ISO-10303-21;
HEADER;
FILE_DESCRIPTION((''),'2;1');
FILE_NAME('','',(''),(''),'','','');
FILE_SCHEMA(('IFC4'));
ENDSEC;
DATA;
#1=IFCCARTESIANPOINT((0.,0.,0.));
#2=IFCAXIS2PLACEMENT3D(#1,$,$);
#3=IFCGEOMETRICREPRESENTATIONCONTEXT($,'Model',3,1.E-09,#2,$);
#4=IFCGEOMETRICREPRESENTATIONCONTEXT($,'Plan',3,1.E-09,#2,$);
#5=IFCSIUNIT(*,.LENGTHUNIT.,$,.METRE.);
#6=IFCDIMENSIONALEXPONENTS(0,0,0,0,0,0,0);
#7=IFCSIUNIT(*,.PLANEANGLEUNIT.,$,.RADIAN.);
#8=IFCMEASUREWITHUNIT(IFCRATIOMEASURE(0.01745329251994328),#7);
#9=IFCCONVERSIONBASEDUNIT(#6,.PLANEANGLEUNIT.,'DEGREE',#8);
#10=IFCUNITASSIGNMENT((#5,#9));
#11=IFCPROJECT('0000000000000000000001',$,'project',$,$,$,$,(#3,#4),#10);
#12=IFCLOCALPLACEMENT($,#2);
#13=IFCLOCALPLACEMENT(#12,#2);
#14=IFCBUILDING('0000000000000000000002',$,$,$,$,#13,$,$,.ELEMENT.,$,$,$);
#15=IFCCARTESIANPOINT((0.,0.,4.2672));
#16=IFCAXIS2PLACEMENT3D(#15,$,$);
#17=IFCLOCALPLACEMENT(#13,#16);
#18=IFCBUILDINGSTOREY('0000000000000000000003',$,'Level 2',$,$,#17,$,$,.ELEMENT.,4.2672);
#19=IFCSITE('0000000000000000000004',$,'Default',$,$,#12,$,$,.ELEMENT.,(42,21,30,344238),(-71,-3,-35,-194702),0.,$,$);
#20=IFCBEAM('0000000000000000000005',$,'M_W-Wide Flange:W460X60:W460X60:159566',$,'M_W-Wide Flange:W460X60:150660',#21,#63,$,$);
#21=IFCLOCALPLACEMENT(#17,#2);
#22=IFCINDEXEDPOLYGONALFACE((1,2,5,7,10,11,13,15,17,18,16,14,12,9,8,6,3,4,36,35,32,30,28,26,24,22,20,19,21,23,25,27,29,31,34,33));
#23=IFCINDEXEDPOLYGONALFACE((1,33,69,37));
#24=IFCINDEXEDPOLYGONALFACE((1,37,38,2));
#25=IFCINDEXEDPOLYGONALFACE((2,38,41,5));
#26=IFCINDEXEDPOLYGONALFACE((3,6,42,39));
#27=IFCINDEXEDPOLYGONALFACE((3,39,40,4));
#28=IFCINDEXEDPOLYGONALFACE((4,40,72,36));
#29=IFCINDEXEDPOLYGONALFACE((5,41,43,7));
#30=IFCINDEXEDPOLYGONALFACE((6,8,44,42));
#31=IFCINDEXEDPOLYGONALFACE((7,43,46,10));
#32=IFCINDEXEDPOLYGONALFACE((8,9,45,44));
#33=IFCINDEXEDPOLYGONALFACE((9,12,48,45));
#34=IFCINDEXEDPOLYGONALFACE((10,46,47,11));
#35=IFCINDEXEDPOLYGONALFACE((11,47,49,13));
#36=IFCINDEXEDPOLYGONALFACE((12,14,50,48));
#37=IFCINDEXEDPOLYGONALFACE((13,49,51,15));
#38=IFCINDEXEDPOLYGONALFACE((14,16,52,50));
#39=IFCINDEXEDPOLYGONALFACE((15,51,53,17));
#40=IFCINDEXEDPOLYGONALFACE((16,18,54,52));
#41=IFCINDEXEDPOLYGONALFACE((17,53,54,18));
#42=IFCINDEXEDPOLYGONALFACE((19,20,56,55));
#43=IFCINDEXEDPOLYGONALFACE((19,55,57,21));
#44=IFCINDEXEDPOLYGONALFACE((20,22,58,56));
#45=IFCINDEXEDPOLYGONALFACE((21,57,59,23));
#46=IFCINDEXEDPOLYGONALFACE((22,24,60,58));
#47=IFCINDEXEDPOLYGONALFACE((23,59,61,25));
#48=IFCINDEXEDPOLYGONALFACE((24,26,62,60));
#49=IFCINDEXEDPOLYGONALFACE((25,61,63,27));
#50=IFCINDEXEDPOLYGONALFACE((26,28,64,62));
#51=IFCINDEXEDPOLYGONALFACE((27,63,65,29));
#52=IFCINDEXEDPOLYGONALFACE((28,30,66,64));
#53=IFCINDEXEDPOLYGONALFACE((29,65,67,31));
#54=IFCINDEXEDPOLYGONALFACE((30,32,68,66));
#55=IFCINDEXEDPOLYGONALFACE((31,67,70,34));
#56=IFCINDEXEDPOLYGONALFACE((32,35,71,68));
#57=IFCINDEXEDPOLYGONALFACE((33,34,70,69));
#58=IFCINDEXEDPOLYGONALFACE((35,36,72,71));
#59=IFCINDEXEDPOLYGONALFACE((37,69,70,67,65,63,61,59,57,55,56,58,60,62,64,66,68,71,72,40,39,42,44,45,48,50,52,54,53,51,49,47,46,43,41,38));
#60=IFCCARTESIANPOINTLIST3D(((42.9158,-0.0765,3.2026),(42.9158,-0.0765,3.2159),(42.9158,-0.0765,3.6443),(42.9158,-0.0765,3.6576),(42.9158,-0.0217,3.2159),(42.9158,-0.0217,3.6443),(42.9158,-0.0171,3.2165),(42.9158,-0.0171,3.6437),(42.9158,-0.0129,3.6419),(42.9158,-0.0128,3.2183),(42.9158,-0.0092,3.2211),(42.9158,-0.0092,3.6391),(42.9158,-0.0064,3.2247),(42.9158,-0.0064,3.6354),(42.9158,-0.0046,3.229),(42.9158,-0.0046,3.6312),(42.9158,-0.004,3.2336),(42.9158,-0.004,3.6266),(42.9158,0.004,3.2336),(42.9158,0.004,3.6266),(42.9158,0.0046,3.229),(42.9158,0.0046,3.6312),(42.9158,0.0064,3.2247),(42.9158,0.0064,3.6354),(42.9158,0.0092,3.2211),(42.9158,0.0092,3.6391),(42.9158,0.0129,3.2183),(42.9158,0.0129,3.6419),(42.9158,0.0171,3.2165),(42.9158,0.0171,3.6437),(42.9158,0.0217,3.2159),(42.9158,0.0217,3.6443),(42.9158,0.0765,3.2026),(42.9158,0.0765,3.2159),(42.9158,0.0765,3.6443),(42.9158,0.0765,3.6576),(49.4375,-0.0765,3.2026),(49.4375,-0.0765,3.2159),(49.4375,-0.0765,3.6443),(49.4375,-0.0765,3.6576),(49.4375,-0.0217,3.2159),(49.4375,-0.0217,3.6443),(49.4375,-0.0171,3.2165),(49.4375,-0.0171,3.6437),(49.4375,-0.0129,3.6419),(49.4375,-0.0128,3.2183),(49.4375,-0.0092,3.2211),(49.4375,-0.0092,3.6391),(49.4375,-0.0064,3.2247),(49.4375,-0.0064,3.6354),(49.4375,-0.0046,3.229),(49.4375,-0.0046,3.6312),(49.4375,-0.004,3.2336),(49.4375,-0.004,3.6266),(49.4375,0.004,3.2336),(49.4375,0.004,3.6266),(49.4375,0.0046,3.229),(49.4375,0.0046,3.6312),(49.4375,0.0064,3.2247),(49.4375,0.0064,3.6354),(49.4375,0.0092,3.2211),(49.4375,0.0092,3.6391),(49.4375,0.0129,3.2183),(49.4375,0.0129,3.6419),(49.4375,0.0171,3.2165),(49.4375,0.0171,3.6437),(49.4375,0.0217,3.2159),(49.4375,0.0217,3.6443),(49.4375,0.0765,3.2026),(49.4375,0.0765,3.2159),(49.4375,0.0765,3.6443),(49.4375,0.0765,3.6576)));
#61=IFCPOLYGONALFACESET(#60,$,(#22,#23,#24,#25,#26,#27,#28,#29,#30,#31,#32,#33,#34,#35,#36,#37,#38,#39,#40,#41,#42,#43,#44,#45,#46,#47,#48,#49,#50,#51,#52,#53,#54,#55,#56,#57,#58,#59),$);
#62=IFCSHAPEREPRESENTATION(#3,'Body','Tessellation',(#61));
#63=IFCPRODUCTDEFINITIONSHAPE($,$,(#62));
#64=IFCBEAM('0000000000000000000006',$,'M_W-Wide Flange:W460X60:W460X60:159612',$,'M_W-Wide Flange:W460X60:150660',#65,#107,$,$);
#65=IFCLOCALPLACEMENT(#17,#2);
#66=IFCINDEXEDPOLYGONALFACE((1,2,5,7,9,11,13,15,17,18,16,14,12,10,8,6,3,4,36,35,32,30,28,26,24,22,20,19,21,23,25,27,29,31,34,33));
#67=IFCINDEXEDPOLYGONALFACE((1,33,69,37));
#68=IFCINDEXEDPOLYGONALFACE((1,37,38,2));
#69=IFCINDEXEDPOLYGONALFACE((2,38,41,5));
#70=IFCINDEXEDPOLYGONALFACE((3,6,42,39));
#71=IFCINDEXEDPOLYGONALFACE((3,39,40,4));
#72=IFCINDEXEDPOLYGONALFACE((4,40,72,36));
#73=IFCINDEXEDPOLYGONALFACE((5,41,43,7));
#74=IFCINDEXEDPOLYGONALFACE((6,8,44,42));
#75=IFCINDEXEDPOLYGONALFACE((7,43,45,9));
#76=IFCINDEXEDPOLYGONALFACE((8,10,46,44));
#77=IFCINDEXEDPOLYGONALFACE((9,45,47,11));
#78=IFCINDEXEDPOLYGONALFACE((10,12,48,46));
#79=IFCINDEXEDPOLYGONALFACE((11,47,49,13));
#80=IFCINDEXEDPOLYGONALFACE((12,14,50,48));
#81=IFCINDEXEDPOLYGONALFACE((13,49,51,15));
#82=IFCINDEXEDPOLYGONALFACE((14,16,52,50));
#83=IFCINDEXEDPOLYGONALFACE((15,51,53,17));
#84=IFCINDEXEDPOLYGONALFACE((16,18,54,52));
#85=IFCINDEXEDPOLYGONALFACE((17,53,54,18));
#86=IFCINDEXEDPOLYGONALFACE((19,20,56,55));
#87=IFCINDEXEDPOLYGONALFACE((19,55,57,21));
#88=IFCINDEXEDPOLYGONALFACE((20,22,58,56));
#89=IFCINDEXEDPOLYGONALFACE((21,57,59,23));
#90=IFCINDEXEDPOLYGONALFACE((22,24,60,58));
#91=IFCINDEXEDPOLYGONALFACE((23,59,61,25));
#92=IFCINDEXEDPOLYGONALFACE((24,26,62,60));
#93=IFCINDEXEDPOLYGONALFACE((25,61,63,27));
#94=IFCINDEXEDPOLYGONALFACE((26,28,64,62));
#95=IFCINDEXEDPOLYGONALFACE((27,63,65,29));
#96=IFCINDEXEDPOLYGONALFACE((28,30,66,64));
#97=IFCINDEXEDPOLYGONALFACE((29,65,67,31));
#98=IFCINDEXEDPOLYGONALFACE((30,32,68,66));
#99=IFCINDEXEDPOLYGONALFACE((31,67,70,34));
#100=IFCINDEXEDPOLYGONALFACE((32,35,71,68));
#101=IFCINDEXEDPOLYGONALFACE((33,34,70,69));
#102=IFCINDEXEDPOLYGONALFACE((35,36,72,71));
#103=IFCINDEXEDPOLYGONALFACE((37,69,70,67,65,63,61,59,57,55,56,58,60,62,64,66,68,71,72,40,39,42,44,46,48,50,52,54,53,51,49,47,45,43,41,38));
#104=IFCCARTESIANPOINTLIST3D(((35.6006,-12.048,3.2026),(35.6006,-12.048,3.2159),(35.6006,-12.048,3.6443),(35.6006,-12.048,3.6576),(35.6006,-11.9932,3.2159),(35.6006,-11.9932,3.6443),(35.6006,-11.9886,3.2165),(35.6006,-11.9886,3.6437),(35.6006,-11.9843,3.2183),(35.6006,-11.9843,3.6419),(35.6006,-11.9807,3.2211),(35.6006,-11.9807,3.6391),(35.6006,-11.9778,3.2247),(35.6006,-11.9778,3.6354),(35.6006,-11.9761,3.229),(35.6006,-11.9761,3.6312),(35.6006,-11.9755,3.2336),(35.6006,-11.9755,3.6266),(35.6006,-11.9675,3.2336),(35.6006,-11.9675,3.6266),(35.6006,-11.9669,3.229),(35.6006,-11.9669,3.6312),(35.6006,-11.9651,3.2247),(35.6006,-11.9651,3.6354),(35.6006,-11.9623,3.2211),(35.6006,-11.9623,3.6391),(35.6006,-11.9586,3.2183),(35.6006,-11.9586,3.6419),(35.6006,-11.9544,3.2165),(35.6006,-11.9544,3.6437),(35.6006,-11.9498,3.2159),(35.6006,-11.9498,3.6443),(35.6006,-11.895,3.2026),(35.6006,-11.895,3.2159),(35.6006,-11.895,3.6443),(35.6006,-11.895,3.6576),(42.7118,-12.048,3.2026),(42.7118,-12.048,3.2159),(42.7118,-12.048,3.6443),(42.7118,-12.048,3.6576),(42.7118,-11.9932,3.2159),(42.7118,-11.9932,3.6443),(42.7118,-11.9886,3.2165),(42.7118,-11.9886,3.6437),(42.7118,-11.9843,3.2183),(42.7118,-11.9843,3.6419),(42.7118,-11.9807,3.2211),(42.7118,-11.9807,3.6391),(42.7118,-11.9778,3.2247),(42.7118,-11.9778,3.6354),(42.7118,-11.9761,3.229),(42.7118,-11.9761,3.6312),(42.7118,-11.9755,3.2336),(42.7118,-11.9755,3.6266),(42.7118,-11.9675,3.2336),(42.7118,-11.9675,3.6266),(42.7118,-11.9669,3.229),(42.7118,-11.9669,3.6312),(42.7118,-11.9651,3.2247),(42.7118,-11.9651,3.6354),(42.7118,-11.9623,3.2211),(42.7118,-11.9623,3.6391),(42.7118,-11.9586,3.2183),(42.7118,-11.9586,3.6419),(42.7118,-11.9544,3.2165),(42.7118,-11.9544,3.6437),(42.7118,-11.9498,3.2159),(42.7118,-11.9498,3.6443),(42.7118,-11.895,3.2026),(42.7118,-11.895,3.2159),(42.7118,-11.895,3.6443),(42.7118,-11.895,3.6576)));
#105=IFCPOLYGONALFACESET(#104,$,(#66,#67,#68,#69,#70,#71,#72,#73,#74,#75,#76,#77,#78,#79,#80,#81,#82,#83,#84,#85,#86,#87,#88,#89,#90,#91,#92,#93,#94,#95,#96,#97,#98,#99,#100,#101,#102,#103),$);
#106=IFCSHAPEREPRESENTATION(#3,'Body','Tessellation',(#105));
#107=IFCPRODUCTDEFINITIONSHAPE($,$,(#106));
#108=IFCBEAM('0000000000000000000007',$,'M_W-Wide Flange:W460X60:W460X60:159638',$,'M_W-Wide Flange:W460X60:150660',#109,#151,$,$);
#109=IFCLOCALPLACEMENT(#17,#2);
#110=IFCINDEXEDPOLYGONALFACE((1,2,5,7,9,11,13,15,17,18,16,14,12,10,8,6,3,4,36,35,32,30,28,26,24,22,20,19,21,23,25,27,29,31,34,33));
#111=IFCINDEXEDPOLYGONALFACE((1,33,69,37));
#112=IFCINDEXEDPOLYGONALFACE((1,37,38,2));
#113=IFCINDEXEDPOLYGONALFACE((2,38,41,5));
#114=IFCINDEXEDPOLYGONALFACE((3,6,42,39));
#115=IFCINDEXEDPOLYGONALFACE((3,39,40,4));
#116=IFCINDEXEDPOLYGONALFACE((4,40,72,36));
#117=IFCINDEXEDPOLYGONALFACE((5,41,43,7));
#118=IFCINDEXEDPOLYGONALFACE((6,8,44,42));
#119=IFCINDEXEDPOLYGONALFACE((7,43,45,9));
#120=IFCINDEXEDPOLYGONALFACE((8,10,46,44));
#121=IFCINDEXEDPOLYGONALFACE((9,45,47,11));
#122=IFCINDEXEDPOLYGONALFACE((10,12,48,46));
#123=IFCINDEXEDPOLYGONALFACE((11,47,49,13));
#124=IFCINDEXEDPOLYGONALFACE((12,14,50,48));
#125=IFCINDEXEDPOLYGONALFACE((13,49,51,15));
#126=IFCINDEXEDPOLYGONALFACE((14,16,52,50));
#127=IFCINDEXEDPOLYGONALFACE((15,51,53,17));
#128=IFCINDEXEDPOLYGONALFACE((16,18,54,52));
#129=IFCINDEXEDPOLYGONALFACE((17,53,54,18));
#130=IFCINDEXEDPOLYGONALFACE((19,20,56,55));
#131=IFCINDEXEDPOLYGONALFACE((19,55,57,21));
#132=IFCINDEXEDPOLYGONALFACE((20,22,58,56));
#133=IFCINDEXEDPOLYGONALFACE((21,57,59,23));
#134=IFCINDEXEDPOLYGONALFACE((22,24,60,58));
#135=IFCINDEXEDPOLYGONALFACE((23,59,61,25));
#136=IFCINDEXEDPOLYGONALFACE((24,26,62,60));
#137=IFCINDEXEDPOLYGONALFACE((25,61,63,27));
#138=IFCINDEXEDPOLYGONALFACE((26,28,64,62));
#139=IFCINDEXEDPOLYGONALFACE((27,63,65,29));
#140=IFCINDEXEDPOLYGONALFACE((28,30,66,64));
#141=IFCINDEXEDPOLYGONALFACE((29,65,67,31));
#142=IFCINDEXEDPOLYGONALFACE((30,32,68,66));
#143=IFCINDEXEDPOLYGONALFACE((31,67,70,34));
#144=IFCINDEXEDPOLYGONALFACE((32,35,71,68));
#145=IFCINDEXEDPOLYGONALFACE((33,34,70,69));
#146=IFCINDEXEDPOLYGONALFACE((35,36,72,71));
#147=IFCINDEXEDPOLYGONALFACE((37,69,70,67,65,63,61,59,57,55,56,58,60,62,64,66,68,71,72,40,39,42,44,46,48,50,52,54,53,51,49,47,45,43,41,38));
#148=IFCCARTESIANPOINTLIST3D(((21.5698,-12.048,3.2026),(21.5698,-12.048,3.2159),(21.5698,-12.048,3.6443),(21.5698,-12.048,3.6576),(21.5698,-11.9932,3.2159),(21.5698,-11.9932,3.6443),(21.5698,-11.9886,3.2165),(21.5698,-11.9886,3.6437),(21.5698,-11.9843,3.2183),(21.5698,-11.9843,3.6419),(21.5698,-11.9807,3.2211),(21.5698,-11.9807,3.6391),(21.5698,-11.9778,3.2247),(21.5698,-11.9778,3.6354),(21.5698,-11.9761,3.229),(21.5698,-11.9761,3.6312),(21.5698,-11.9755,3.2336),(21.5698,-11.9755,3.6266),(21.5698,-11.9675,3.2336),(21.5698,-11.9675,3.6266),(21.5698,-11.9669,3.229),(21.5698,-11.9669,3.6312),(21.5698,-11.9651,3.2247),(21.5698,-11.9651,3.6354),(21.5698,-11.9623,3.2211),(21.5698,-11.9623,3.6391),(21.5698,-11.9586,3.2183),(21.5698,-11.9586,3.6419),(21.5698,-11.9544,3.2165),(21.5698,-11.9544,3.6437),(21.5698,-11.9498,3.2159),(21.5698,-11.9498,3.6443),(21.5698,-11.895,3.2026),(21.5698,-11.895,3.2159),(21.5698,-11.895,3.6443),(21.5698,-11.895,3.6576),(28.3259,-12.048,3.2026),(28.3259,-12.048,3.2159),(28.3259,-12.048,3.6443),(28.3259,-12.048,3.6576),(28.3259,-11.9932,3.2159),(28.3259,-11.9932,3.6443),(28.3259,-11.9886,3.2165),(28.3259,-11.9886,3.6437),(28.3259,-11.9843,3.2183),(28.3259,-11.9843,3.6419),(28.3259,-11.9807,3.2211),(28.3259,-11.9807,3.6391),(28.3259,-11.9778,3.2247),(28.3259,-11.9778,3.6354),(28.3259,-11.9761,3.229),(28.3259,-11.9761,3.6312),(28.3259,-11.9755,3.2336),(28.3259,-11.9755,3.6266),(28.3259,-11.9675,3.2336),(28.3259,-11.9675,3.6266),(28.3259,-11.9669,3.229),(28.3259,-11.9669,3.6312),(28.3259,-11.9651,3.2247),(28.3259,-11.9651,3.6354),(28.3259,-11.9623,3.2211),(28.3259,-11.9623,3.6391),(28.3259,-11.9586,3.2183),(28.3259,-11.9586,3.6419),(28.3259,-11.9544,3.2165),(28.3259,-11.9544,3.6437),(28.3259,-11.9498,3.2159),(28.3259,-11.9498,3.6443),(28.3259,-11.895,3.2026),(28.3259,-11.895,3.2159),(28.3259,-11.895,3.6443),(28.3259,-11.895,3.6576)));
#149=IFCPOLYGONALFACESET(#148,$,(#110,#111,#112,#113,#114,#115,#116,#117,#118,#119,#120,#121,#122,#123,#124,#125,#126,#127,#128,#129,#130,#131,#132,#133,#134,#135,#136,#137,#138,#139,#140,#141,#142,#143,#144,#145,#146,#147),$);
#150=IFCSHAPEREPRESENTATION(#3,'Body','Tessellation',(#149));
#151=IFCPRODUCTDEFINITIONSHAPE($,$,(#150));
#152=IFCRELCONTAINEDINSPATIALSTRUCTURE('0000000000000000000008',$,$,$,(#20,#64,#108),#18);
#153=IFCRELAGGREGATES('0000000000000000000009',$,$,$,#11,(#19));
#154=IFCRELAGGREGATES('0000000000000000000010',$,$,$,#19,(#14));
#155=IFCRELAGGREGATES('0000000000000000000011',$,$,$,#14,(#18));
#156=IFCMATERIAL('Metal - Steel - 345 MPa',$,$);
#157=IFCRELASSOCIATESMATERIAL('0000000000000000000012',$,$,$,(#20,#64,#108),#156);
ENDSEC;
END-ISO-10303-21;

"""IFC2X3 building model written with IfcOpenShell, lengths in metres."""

from ifc_helpers import new_model, entity, si_unit, converted_unit, frame, frame_2d, origin, place, context, project, spatial, polyline, circle_curve, parameter, trimmed, segment, composite_curve, outline, extrude, material, element, save


model = new_model("IFC2X3")

# Units and contexts
model_context = context("Model", 3, precision=1e-09, world=origin())
plan_context = context("Plan", 3, precision=1e-09, world=origin())
ifc_project = project(units=[si_unit("LENGTHUNIT", "METRE"), converted_unit("PLANEANGLEUNIT", "DEGREE", entity("IfcRatioMeasure", 0.01745329251994328), si_unit("PLANEANGLEUNIT", "RADIAN"), dimensions=[0, 0, 0, 0, 0, 0, 0])], contexts=[model_context, plan_context])

# Site, building, storey
site_placement = place(None, origin())
site = spatial("IfcSite", under=ifc_project, at=site_placement, Name="Default", CompositionType="ELEMENT", RefLatitude=(42, 21, 30, 344238), RefLongitude=(-71, -3, -35, -194702), RefElevation=0.0)
building_placement = place(site_placement, origin())
building = spatial("IfcBuilding", under=site, at=building_placement, CompositionType="ELEMENT")
storey_placement = place(building_placement, frame((0.0, 0.0, 4.2672)))
storey = spatial("IfcBuildingStorey", under=building, at=storey_placement, Name="Level 2", CompositionType="ELEMENT", Elevation=4.2672)

# Shared definitions
ifc_material = material(Name="Metal - Steel - 345 MPa")

# Beams
beam_1_placement = place(storey_placement, frame((42.8138, 0.0, 3.6576), z_axis=(0.0, 0.0, 1.0), x_axis=(0.0, -1.0, 0.0)))
element("IfcBeam", 1, at=beam_1_placement, inside=storey, material=ifc_material, Name="M_W-Wide Flange:W460X60:W460X60:159566", ObjectType="M_W-Wide Flange:W460X60:150660", context=model_context, shape_type="SweptSolid", body=[
    extrude(outline(composite_curve([segment(polyline([(-0.0765, -0.2142), (-0.0765, -0.2275)]), True, "CONTINUOUS"), segment(polyline([(-0.0765, -0.2275), (0.0765, -0.2275)]), True, "CONTINUOUS"), segment(polyline([(0.0765, -0.2275), (0.0765, -0.2142)]), True, "CONTINUOUS"), segment(polyline([(0.0765, -0.2142), (0.0217, -0.2142)]), True, "CONTINUOUS"), segment(trimmed(circle_curve(frame_2d((0.0217, -0.1965), x_axis=(0.0, -1.0)), 0.0177), [parameter(270.0)], [parameter(360.0)], True, "PARAMETER"), False, "CONTINUOUS"), segment(polyline([(0.004, -0.1965), (0.004, 0.1965)]), True, "CONTINUOUS"), segment(trimmed(circle_curve(frame_2d((0.0217, 0.1965), x_axis=(-1.0, 0.0)), 0.0177), [parameter(270.0)], [parameter(360.0)], True, "PARAMETER"), False, "CONTINUOUS"), segment(polyline([(0.0217, 0.2142), (0.0765, 0.2142)]), True, "CONTINUOUS"), segment(polyline([(0.0765, 0.2142), (0.0765, 0.2275)]), True, "CONTINUOUS"), segment(polyline([(0.0765, 0.2275), (-0.0765, 0.2275)]), True, "CONTINUOUS"), segment(polyline([(-0.0765, 0.2275), (-0.0765, 0.2142)]), True, "CONTINUOUS"), segment(polyline([(-0.0765, 0.2142), (-0.0217, 0.2142)]), True, "CONTINUOUS"), segment(trimmed(circle_curve(frame_2d((-0.0217, 0.1965), x_axis=(0.0, 1.0)), 0.0177), [parameter(270.0)], [parameter(360.0)], True, "PARAMETER"), False, "CONTINUOUS"), segment(polyline([(-0.004, 0.1965), (-0.004, -0.1965)]), True, "CONTINUOUS"), segment(trimmed(circle_curve(frame_2d((-0.0217, -0.1965), x_axis=(1.0, 0.0)), 0.0177), [parameter(270.0)], [parameter(0.0)], True, "PARAMETER"), False, "CONTINUOUS"), segment(polyline([(-0.0217, -0.2142), (-0.0765, -0.2142)]), True, "CONTINUOUS")], self_intersect=False)), frame((0.0, 0.102, -0.2275), z_axis=(0.0, -1.0, 0.0), x_axis=(1.0, 0.0, 0.0)), (0.0, 0.0, -1.0), 6.5217),
])
beam_2_placement = place(storey_placement, frame((42.8138, -11.9715, 3.6576), z_axis=(0.0, 0.0, 1.0), x_axis=(0.0, 1.0, 0.0)))
element("IfcBeam", 2, at=beam_2_placement, inside=storey, material=ifc_material, Name="M_W-Wide Flange:W460X60:W460X60:159612", ObjectType="M_W-Wide Flange:W460X60:150660", context=model_context, shape_type="SweptSolid", body=[
    extrude(outline(composite_curve([segment(polyline([(0.2142, -0.0765), (0.2275, -0.0765)]), True, "CONTINUOUS"), segment(polyline([(0.2275, -0.0765), (0.2275, 0.0765)]), True, "CONTINUOUS"), segment(polyline([(0.2275, 0.0765), (0.2142, 0.0765)]), True, "CONTINUOUS"), segment(polyline([(0.2142, 0.0765), (0.2142, 0.0217)]), True, "CONTINUOUS"), segment(trimmed(circle_curve(frame_2d((0.1965, 0.0217), x_axis=(1.0, 0.0)), 0.0177), [parameter(270.0)], [parameter(360.0)], True, "PARAMETER"), False, "CONTINUOUS"), segment(polyline([(0.1965, 0.004), (-0.1965, 0.004)]), True, "CONTINUOUS"), segment(trimmed(circle_curve(frame_2d((-0.1965, 0.0217), x_axis=(0.0, -1.0)), 0.0177), [parameter(270.0)], [parameter(360.0)], True, "PARAMETER"), False, "CONTINUOUS"), segment(polyline([(-0.2142, 0.0217), (-0.2142, 0.0765)]), True, "CONTINUOUS"), segment(polyline([(-0.2142, 0.0765), (-0.2275, 0.0765)]), True, "CONTINUOUS"), segment(polyline([(-0.2275, 0.0765), (-0.2275, -0.0765)]), True, "CONTINUOUS"), segment(polyline([(-0.2275, -0.0765), (-0.2142, -0.0765)]), True, "CONTINUOUS"), segment(polyline([(-0.2142, -0.0765), (-0.2142, -0.0217)]), True, "CONTINUOUS"), segment(trimmed(circle_curve(frame_2d((-0.1965, -0.0217), x_axis=(-1.0, 0.0)), 0.0177), [parameter(270.0)], [parameter(360.0)], True, "PARAMETER"), False, "CONTINUOUS"), segment(polyline([(-0.1965, -0.004), (0.1965, -0.004)]), True, "CONTINUOUS"), segment(trimmed(circle_curve(frame_2d((0.1965, -0.0217), x_axis=(0.0, 1.0)), 0.0177), [parameter(270.0)], [parameter(0.0)], True, "PARAMETER"), False, "CONTINUOUS"), segment(polyline([(0.2142, -0.0217), (0.2142, -0.0765)]), True, "CONTINUOUS")], self_intersect=False)), frame((0.0, 7.2132, -0.2275), z_axis=(0.0, -1.0, 0.0), x_axis=(0.0, 0.0, -1.0)), (0.0, 0.0, 1.0), 7.1112),
])
beam_3_placement = place(storey_placement, frame((28.4279, -11.9715, 3.6576), z_axis=(0.0, 0.0, 1.0), x_axis=(0.0, 1.0, 0.0)))
element("IfcBeam", 3, at=beam_3_placement, inside=storey, material=ifc_material, Name="M_W-Wide Flange:W460X60:W460X60:159638", ObjectType="M_W-Wide Flange:W460X60:150660", context=model_context, shape_type="SweptSolid", body=[
    extrude(outline(composite_curve([segment(polyline([(0.2142, -0.0765), (0.2275, -0.0765)]), True, "CONTINUOUS"), segment(polyline([(0.2275, -0.0765), (0.2275, 0.0765)]), True, "CONTINUOUS"), segment(polyline([(0.2275, 0.0765), (0.2142, 0.0765)]), True, "CONTINUOUS"), segment(polyline([(0.2142, 0.0765), (0.2142, 0.0217)]), True, "CONTINUOUS"), segment(trimmed(circle_curve(frame_2d((0.1965, 0.0217), x_axis=(1.0, 0.0)), 0.0177), [parameter(270.0)], [parameter(360.0)], True, "PARAMETER"), False, "CONTINUOUS"), segment(polyline([(0.1965, 0.004), (-0.1965, 0.004)]), True, "CONTINUOUS"), segment(trimmed(circle_curve(frame_2d((-0.1965, 0.0217), x_axis=(0.0, -1.0)), 0.0177), [parameter(270.0)], [parameter(360.0)], True, "PARAMETER"), False, "CONTINUOUS"), segment(polyline([(-0.2142, 0.0217), (-0.2142, 0.0765)]), True, "CONTINUOUS"), segment(polyline([(-0.2142, 0.0765), (-0.2275, 0.0765)]), True, "CONTINUOUS"), segment(polyline([(-0.2275, 0.0765), (-0.2275, -0.0765)]), True, "CONTINUOUS"), segment(polyline([(-0.2275, -0.0765), (-0.2142, -0.0765)]), True, "CONTINUOUS"), segment(polyline([(-0.2142, -0.0765), (-0.2142, -0.0217)]), True, "CONTINUOUS"), segment(trimmed(circle_curve(frame_2d((-0.1965, -0.0217), x_axis=(-1.0, 0.0)), 0.0177), [parameter(270.0)], [parameter(360.0)], True, "PARAMETER"), False, "CONTINUOUS"), segment(polyline([(-0.1965, -0.004), (0.1965, -0.004)]), True, "CONTINUOUS"), segment(trimmed(circle_curve(frame_2d((0.1965, -0.0217), x_axis=(0.0, 1.0)), 0.0177), [parameter(270.0)], [parameter(0.0)], True, "PARAMETER"), False, "CONTINUOUS"), segment(polyline([(0.2142, -0.0217), (0.2142, -0.0765)]), True, "CONTINUOUS")], self_intersect=False)), frame((0.0, 6.8581, -0.2275), z_axis=(0.0, -1.0, 0.0), x_axis=(0.0, 0.0, -1.0)), (0.0, 0.0, 1.0), 6.7561),
])

save(model, "model.ifc")
